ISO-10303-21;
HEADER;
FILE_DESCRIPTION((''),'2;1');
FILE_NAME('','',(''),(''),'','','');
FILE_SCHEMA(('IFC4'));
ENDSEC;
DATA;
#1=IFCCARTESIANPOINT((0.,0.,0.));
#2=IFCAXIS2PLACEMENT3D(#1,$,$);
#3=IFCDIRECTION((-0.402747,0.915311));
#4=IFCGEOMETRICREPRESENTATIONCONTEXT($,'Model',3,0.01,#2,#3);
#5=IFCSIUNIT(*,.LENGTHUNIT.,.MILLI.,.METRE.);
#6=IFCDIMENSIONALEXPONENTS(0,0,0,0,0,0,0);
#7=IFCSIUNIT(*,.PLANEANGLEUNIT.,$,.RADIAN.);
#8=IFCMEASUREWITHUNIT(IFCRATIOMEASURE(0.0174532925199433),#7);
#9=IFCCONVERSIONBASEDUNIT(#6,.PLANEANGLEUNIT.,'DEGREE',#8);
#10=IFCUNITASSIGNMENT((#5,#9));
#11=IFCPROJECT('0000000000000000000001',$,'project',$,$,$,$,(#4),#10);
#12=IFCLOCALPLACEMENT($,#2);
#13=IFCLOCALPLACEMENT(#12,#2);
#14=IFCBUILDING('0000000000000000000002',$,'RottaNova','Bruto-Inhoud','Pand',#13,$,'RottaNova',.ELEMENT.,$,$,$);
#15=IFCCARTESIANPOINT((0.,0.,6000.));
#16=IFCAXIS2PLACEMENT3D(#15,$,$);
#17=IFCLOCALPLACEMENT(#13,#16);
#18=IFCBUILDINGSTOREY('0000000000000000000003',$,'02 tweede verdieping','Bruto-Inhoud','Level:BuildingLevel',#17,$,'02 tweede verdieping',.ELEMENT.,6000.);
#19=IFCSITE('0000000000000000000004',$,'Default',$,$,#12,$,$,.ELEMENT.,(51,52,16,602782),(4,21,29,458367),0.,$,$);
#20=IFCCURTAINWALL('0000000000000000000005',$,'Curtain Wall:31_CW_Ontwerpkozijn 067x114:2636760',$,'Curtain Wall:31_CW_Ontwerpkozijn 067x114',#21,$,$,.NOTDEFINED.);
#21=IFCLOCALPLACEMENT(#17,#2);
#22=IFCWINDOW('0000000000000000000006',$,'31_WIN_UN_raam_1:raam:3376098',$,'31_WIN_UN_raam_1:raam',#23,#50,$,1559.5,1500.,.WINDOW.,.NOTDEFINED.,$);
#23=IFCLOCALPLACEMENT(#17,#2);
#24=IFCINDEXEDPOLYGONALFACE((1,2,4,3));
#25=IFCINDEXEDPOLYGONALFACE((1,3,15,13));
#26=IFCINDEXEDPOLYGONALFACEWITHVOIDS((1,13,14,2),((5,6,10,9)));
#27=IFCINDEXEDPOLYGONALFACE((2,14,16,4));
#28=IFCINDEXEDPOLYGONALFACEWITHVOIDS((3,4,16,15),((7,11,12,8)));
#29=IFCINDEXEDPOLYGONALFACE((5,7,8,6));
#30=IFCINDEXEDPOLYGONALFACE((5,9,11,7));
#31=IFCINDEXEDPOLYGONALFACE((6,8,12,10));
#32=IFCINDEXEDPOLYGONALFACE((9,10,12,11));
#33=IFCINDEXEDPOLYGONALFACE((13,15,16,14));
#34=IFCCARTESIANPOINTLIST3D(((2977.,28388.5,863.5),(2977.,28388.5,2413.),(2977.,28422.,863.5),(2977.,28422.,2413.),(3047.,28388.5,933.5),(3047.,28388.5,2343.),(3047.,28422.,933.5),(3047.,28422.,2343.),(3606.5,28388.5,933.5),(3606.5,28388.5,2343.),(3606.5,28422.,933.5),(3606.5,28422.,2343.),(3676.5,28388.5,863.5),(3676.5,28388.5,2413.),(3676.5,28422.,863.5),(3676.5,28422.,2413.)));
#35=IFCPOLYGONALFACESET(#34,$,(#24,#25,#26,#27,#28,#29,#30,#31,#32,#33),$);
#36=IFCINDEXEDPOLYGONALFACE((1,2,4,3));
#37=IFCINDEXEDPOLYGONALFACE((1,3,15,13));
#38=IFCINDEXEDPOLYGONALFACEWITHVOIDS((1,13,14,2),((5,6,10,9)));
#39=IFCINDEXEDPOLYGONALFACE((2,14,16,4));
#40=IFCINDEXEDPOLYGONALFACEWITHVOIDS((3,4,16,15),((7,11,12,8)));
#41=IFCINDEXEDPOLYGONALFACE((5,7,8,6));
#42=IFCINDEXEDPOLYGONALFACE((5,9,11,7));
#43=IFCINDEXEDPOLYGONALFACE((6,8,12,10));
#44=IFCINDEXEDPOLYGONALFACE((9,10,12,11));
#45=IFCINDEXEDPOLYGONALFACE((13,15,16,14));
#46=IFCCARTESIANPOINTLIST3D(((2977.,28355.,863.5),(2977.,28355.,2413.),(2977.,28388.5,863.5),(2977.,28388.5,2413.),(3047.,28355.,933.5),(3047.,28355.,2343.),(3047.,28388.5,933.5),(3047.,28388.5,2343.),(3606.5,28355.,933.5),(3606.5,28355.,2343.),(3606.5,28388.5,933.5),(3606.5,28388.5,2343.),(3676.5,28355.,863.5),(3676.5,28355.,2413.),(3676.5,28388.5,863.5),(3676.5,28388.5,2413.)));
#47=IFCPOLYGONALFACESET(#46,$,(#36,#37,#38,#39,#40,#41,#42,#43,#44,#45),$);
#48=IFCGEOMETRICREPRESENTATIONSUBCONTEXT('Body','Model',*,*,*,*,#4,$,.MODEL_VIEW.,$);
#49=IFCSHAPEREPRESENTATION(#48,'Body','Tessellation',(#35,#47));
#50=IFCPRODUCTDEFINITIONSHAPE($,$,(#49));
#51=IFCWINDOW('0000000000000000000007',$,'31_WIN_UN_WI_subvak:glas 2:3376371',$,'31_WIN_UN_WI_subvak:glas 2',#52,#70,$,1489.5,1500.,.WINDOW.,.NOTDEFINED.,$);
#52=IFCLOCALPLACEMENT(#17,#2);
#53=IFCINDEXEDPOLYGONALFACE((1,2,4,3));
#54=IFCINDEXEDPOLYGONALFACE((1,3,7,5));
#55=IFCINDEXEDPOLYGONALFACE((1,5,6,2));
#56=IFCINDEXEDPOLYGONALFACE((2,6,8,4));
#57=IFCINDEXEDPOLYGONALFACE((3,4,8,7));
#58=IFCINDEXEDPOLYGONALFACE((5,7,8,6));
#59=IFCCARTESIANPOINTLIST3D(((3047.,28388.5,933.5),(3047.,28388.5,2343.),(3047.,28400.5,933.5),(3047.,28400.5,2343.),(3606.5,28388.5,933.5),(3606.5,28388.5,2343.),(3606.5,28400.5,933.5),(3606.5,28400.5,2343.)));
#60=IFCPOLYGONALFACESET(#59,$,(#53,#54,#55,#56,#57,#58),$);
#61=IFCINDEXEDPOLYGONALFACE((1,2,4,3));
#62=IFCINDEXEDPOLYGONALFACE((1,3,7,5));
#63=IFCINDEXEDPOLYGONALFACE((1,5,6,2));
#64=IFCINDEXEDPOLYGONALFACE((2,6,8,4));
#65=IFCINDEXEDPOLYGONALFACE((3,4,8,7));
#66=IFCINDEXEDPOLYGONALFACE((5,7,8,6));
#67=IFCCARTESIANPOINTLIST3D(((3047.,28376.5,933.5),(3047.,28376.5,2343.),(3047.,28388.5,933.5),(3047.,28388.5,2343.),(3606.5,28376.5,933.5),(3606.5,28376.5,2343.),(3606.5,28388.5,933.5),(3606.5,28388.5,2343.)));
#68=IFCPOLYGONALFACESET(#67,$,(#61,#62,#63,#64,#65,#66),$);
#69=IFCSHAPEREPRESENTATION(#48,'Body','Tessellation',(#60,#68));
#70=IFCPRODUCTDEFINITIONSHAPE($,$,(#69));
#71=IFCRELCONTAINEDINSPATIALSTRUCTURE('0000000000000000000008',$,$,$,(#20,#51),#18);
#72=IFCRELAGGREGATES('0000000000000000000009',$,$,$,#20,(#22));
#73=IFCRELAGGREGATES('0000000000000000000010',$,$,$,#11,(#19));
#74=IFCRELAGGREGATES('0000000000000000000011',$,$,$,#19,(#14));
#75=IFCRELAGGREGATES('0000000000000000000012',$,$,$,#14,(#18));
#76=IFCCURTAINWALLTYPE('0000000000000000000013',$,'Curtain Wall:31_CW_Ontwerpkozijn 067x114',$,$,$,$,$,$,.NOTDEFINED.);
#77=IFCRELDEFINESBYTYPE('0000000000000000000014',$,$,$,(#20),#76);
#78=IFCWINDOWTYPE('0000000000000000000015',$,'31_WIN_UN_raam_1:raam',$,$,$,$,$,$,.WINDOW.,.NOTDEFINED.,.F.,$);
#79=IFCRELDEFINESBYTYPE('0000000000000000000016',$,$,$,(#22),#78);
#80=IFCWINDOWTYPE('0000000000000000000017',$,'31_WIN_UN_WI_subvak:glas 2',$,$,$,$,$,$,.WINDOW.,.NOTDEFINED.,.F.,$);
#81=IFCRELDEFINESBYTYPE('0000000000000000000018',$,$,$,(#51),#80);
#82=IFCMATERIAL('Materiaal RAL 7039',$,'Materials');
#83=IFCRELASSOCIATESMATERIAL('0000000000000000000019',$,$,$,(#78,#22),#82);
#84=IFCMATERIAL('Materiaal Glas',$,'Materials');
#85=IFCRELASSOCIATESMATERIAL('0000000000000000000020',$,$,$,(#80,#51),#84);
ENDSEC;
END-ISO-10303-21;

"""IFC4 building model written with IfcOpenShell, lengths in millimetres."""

from ifc_helpers import new_model, entity, si_unit, converted_unit, direction, frame, frame_2d, origin, origin_2d_with_axis, place, context, subcontext, project, spatial, polyline, rectangle, outline, extrude, source, transform, mapped, material, type_object, type_shapes, element, aggregate, save


model = new_model("IFC4")

# Units and contexts
model_context = context("Model", 3, precision=0.01, world=origin(), true_north=direction((-0.402747, 0.915311)))
body_context = subcontext(model_context, "Body", "Model", "MODEL_VIEW")
ifc_project = project(units=[si_unit("LENGTHUNIT", "METRE", prefix="MILLI"), converted_unit("PLANEANGLEUNIT", "DEGREE", entity("IfcRatioMeasure", 0.0174532925199433), si_unit("PLANEANGLEUNIT", "RADIAN"), dimensions=[0, 0, 0, 0, 0, 0, 0])], contexts=[model_context])

# Site, building, storey
site_placement = place(None, origin())
site = spatial("IfcSite", under=ifc_project, at=site_placement, Name="Default", CompositionType="ELEMENT", RefLatitude=(51, 52, 16, 602782), RefLongitude=(4, 21, 29, 458367), RefElevation=0.0)
building_placement = place(site_placement, origin())
building = spatial("IfcBuilding", under=site, at=building_placement, Name="RottaNova", Description="Bruto-Inhoud", ObjectType="Pand", LongName="RottaNova", CompositionType="ELEMENT")
storey_placement = place(building_placement, frame((0.0, 0.0, 6000.0)))
storey = spatial("IfcBuildingStorey", under=building, at=storey_placement, Name="02 tweede verdieping", Description="Bruto-Inhoud", ObjectType="Level:BuildingLevel", LongName="02 tweede verdieping", CompositionType="ELEMENT", Elevation=6000.0)

# Shared definitions
curtain_wall_type = type_object("IfcCurtainWallType", Name="Curtain Wall:31_CW_Ontwerpkozijn 067x114", PredefinedType="NOTDEFINED")
ifc_material_1 = material(Name="Materiaal RAL 7039", Category="Materials")

# Curtain wall
curtain_wall_1_placement = place(storey_placement, frame((0.0, 0.0, -6000.0)))
curtain_wall_1 = element("IfcCurtainWall", 1, at=curtain_wall_1_placement, inside=storey, type_object=curtain_wall_type, Name="Curtain Wall:31_CW_Ontwerpkozijn 067x114:2636760", ObjectType="Curtain Wall:31_CW_Ontwerpkozijn 067x114", PredefinedType="NOTDEFINED")
ifc_material_2 = material(Name="Materiaal Glas", Category="Materials")

# Windows
window_type_1 = type_object("IfcWindowType", Name="31_WIN_UN_raam_1:raam", ParameterTakesPrecedence=False, PartitioningType="NOTDEFINED", PredefinedType="WINDOW", material=ifc_material_1)
shared_shape_1 = source(origin(), body_context, "Body", "SweptSolid", [
    extrude(outline(polyline([(-349.8, -774.7), (349.8, -774.7), (349.8, 774.7), (-349.8, 774.7), (-349.8, -774.7)]), holes=[polyline([(-279.8, 704.7), (279.8, 704.7), (279.8, -704.8), (-279.8, -704.8), (-279.8, 704.7)])]), frame((0.0, 92.0, 774.8), z_axis=(0.0, -1.0, 0.0), x_axis=(-1.0, 0.0, 0.0)), (0.0, 0.0, 1.0), 33.5),
    extrude(outline(polyline([(-349.8, -774.7), (349.8, -774.7), (349.8, 774.7), (-349.8, 774.7), (-349.8, -774.7)]), holes=[polyline([(-279.8, 704.7), (279.8, 704.7), (279.8, -704.8), (-279.8, -704.8), (-279.8, 704.7)])]), frame((0.0, 58.5, 774.8), z_axis=(0.0, -1.0, 0.0), x_axis=(-1.0, 0.0, 0.0)), (0.0, 0.0, 1.0), 33.5),
])
type_shapes(window_type_1, [shared_shape_1])
window_1_placement = place(curtain_wall_1_placement, frame((3326.7, 28330.0, 6863.5)))
window_1 = element("IfcWindow", 2, at=window_1_placement, type_object=window_type_1, material=ifc_material_1, Name="31_WIN_UN_raam_1:raam:3376098", ObjectType="31_WIN_UN_raam_1:raam", OverallHeight=1559.5, OverallWidth=1500.0, PartitioningType="NOTDEFINED", PredefinedType="WINDOW", context=body_context, shape_type="MappedRepresentation", body=[
    mapped(shared_shape_1, transform((0.0, 0.0, 0.0), scale=1.0)),
])
aggregate(curtain_wall_1, [window_1])
window_type_2 = type_object("IfcWindowType", Name="31_WIN_UN_WI_subvak:glas 2", ParameterTakesPrecedence=False, PartitioningType="NOTDEFINED", PredefinedType="WINDOW", material=ifc_material_2)
shared_shape_2 = source(origin(), body_context, "Body", "SweptSolid", [
    extrude(rectangle(XDim=559.5, YDim=12.0, at=frame_2d((0.0, 0.0), x_axis=(1.0, 0.0))), frame((0.0, -6.0, 0.0)), (0.0, 0.0, 1.0), 1409.5),
    extrude(rectangle(XDim=559.5, YDim=12.0, at=origin_2d_with_axis()), frame((0.0, 6.0, 0.0)), (0.0, 0.0, 1.0), 1409.5),
])
type_shapes(window_type_2, [shared_shape_2])
window_2_placement = place(storey_placement, frame((3326.7, 28388.5, 933.5), z_axis=(0.0, 0.0, 1.0), x_axis=(-1.0, 0.0, 0.0)))
element("IfcWindow", 3, at=window_2_placement, inside=storey, type_object=window_type_2, material=ifc_material_2, Name="31_WIN_UN_WI_subvak:glas 2:3376371", ObjectType="31_WIN_UN_WI_subvak:glas 2", OverallHeight=1489.5, OverallWidth=1500.0, PartitioningType="NOTDEFINED", PredefinedType="WINDOW", context=body_context, shape_type="MappedRepresentation", body=[
    mapped(shared_shape_2, transform((0.0, 0.0, 0.0), scale=1.0)),
])

save(model, "model.ifc")
